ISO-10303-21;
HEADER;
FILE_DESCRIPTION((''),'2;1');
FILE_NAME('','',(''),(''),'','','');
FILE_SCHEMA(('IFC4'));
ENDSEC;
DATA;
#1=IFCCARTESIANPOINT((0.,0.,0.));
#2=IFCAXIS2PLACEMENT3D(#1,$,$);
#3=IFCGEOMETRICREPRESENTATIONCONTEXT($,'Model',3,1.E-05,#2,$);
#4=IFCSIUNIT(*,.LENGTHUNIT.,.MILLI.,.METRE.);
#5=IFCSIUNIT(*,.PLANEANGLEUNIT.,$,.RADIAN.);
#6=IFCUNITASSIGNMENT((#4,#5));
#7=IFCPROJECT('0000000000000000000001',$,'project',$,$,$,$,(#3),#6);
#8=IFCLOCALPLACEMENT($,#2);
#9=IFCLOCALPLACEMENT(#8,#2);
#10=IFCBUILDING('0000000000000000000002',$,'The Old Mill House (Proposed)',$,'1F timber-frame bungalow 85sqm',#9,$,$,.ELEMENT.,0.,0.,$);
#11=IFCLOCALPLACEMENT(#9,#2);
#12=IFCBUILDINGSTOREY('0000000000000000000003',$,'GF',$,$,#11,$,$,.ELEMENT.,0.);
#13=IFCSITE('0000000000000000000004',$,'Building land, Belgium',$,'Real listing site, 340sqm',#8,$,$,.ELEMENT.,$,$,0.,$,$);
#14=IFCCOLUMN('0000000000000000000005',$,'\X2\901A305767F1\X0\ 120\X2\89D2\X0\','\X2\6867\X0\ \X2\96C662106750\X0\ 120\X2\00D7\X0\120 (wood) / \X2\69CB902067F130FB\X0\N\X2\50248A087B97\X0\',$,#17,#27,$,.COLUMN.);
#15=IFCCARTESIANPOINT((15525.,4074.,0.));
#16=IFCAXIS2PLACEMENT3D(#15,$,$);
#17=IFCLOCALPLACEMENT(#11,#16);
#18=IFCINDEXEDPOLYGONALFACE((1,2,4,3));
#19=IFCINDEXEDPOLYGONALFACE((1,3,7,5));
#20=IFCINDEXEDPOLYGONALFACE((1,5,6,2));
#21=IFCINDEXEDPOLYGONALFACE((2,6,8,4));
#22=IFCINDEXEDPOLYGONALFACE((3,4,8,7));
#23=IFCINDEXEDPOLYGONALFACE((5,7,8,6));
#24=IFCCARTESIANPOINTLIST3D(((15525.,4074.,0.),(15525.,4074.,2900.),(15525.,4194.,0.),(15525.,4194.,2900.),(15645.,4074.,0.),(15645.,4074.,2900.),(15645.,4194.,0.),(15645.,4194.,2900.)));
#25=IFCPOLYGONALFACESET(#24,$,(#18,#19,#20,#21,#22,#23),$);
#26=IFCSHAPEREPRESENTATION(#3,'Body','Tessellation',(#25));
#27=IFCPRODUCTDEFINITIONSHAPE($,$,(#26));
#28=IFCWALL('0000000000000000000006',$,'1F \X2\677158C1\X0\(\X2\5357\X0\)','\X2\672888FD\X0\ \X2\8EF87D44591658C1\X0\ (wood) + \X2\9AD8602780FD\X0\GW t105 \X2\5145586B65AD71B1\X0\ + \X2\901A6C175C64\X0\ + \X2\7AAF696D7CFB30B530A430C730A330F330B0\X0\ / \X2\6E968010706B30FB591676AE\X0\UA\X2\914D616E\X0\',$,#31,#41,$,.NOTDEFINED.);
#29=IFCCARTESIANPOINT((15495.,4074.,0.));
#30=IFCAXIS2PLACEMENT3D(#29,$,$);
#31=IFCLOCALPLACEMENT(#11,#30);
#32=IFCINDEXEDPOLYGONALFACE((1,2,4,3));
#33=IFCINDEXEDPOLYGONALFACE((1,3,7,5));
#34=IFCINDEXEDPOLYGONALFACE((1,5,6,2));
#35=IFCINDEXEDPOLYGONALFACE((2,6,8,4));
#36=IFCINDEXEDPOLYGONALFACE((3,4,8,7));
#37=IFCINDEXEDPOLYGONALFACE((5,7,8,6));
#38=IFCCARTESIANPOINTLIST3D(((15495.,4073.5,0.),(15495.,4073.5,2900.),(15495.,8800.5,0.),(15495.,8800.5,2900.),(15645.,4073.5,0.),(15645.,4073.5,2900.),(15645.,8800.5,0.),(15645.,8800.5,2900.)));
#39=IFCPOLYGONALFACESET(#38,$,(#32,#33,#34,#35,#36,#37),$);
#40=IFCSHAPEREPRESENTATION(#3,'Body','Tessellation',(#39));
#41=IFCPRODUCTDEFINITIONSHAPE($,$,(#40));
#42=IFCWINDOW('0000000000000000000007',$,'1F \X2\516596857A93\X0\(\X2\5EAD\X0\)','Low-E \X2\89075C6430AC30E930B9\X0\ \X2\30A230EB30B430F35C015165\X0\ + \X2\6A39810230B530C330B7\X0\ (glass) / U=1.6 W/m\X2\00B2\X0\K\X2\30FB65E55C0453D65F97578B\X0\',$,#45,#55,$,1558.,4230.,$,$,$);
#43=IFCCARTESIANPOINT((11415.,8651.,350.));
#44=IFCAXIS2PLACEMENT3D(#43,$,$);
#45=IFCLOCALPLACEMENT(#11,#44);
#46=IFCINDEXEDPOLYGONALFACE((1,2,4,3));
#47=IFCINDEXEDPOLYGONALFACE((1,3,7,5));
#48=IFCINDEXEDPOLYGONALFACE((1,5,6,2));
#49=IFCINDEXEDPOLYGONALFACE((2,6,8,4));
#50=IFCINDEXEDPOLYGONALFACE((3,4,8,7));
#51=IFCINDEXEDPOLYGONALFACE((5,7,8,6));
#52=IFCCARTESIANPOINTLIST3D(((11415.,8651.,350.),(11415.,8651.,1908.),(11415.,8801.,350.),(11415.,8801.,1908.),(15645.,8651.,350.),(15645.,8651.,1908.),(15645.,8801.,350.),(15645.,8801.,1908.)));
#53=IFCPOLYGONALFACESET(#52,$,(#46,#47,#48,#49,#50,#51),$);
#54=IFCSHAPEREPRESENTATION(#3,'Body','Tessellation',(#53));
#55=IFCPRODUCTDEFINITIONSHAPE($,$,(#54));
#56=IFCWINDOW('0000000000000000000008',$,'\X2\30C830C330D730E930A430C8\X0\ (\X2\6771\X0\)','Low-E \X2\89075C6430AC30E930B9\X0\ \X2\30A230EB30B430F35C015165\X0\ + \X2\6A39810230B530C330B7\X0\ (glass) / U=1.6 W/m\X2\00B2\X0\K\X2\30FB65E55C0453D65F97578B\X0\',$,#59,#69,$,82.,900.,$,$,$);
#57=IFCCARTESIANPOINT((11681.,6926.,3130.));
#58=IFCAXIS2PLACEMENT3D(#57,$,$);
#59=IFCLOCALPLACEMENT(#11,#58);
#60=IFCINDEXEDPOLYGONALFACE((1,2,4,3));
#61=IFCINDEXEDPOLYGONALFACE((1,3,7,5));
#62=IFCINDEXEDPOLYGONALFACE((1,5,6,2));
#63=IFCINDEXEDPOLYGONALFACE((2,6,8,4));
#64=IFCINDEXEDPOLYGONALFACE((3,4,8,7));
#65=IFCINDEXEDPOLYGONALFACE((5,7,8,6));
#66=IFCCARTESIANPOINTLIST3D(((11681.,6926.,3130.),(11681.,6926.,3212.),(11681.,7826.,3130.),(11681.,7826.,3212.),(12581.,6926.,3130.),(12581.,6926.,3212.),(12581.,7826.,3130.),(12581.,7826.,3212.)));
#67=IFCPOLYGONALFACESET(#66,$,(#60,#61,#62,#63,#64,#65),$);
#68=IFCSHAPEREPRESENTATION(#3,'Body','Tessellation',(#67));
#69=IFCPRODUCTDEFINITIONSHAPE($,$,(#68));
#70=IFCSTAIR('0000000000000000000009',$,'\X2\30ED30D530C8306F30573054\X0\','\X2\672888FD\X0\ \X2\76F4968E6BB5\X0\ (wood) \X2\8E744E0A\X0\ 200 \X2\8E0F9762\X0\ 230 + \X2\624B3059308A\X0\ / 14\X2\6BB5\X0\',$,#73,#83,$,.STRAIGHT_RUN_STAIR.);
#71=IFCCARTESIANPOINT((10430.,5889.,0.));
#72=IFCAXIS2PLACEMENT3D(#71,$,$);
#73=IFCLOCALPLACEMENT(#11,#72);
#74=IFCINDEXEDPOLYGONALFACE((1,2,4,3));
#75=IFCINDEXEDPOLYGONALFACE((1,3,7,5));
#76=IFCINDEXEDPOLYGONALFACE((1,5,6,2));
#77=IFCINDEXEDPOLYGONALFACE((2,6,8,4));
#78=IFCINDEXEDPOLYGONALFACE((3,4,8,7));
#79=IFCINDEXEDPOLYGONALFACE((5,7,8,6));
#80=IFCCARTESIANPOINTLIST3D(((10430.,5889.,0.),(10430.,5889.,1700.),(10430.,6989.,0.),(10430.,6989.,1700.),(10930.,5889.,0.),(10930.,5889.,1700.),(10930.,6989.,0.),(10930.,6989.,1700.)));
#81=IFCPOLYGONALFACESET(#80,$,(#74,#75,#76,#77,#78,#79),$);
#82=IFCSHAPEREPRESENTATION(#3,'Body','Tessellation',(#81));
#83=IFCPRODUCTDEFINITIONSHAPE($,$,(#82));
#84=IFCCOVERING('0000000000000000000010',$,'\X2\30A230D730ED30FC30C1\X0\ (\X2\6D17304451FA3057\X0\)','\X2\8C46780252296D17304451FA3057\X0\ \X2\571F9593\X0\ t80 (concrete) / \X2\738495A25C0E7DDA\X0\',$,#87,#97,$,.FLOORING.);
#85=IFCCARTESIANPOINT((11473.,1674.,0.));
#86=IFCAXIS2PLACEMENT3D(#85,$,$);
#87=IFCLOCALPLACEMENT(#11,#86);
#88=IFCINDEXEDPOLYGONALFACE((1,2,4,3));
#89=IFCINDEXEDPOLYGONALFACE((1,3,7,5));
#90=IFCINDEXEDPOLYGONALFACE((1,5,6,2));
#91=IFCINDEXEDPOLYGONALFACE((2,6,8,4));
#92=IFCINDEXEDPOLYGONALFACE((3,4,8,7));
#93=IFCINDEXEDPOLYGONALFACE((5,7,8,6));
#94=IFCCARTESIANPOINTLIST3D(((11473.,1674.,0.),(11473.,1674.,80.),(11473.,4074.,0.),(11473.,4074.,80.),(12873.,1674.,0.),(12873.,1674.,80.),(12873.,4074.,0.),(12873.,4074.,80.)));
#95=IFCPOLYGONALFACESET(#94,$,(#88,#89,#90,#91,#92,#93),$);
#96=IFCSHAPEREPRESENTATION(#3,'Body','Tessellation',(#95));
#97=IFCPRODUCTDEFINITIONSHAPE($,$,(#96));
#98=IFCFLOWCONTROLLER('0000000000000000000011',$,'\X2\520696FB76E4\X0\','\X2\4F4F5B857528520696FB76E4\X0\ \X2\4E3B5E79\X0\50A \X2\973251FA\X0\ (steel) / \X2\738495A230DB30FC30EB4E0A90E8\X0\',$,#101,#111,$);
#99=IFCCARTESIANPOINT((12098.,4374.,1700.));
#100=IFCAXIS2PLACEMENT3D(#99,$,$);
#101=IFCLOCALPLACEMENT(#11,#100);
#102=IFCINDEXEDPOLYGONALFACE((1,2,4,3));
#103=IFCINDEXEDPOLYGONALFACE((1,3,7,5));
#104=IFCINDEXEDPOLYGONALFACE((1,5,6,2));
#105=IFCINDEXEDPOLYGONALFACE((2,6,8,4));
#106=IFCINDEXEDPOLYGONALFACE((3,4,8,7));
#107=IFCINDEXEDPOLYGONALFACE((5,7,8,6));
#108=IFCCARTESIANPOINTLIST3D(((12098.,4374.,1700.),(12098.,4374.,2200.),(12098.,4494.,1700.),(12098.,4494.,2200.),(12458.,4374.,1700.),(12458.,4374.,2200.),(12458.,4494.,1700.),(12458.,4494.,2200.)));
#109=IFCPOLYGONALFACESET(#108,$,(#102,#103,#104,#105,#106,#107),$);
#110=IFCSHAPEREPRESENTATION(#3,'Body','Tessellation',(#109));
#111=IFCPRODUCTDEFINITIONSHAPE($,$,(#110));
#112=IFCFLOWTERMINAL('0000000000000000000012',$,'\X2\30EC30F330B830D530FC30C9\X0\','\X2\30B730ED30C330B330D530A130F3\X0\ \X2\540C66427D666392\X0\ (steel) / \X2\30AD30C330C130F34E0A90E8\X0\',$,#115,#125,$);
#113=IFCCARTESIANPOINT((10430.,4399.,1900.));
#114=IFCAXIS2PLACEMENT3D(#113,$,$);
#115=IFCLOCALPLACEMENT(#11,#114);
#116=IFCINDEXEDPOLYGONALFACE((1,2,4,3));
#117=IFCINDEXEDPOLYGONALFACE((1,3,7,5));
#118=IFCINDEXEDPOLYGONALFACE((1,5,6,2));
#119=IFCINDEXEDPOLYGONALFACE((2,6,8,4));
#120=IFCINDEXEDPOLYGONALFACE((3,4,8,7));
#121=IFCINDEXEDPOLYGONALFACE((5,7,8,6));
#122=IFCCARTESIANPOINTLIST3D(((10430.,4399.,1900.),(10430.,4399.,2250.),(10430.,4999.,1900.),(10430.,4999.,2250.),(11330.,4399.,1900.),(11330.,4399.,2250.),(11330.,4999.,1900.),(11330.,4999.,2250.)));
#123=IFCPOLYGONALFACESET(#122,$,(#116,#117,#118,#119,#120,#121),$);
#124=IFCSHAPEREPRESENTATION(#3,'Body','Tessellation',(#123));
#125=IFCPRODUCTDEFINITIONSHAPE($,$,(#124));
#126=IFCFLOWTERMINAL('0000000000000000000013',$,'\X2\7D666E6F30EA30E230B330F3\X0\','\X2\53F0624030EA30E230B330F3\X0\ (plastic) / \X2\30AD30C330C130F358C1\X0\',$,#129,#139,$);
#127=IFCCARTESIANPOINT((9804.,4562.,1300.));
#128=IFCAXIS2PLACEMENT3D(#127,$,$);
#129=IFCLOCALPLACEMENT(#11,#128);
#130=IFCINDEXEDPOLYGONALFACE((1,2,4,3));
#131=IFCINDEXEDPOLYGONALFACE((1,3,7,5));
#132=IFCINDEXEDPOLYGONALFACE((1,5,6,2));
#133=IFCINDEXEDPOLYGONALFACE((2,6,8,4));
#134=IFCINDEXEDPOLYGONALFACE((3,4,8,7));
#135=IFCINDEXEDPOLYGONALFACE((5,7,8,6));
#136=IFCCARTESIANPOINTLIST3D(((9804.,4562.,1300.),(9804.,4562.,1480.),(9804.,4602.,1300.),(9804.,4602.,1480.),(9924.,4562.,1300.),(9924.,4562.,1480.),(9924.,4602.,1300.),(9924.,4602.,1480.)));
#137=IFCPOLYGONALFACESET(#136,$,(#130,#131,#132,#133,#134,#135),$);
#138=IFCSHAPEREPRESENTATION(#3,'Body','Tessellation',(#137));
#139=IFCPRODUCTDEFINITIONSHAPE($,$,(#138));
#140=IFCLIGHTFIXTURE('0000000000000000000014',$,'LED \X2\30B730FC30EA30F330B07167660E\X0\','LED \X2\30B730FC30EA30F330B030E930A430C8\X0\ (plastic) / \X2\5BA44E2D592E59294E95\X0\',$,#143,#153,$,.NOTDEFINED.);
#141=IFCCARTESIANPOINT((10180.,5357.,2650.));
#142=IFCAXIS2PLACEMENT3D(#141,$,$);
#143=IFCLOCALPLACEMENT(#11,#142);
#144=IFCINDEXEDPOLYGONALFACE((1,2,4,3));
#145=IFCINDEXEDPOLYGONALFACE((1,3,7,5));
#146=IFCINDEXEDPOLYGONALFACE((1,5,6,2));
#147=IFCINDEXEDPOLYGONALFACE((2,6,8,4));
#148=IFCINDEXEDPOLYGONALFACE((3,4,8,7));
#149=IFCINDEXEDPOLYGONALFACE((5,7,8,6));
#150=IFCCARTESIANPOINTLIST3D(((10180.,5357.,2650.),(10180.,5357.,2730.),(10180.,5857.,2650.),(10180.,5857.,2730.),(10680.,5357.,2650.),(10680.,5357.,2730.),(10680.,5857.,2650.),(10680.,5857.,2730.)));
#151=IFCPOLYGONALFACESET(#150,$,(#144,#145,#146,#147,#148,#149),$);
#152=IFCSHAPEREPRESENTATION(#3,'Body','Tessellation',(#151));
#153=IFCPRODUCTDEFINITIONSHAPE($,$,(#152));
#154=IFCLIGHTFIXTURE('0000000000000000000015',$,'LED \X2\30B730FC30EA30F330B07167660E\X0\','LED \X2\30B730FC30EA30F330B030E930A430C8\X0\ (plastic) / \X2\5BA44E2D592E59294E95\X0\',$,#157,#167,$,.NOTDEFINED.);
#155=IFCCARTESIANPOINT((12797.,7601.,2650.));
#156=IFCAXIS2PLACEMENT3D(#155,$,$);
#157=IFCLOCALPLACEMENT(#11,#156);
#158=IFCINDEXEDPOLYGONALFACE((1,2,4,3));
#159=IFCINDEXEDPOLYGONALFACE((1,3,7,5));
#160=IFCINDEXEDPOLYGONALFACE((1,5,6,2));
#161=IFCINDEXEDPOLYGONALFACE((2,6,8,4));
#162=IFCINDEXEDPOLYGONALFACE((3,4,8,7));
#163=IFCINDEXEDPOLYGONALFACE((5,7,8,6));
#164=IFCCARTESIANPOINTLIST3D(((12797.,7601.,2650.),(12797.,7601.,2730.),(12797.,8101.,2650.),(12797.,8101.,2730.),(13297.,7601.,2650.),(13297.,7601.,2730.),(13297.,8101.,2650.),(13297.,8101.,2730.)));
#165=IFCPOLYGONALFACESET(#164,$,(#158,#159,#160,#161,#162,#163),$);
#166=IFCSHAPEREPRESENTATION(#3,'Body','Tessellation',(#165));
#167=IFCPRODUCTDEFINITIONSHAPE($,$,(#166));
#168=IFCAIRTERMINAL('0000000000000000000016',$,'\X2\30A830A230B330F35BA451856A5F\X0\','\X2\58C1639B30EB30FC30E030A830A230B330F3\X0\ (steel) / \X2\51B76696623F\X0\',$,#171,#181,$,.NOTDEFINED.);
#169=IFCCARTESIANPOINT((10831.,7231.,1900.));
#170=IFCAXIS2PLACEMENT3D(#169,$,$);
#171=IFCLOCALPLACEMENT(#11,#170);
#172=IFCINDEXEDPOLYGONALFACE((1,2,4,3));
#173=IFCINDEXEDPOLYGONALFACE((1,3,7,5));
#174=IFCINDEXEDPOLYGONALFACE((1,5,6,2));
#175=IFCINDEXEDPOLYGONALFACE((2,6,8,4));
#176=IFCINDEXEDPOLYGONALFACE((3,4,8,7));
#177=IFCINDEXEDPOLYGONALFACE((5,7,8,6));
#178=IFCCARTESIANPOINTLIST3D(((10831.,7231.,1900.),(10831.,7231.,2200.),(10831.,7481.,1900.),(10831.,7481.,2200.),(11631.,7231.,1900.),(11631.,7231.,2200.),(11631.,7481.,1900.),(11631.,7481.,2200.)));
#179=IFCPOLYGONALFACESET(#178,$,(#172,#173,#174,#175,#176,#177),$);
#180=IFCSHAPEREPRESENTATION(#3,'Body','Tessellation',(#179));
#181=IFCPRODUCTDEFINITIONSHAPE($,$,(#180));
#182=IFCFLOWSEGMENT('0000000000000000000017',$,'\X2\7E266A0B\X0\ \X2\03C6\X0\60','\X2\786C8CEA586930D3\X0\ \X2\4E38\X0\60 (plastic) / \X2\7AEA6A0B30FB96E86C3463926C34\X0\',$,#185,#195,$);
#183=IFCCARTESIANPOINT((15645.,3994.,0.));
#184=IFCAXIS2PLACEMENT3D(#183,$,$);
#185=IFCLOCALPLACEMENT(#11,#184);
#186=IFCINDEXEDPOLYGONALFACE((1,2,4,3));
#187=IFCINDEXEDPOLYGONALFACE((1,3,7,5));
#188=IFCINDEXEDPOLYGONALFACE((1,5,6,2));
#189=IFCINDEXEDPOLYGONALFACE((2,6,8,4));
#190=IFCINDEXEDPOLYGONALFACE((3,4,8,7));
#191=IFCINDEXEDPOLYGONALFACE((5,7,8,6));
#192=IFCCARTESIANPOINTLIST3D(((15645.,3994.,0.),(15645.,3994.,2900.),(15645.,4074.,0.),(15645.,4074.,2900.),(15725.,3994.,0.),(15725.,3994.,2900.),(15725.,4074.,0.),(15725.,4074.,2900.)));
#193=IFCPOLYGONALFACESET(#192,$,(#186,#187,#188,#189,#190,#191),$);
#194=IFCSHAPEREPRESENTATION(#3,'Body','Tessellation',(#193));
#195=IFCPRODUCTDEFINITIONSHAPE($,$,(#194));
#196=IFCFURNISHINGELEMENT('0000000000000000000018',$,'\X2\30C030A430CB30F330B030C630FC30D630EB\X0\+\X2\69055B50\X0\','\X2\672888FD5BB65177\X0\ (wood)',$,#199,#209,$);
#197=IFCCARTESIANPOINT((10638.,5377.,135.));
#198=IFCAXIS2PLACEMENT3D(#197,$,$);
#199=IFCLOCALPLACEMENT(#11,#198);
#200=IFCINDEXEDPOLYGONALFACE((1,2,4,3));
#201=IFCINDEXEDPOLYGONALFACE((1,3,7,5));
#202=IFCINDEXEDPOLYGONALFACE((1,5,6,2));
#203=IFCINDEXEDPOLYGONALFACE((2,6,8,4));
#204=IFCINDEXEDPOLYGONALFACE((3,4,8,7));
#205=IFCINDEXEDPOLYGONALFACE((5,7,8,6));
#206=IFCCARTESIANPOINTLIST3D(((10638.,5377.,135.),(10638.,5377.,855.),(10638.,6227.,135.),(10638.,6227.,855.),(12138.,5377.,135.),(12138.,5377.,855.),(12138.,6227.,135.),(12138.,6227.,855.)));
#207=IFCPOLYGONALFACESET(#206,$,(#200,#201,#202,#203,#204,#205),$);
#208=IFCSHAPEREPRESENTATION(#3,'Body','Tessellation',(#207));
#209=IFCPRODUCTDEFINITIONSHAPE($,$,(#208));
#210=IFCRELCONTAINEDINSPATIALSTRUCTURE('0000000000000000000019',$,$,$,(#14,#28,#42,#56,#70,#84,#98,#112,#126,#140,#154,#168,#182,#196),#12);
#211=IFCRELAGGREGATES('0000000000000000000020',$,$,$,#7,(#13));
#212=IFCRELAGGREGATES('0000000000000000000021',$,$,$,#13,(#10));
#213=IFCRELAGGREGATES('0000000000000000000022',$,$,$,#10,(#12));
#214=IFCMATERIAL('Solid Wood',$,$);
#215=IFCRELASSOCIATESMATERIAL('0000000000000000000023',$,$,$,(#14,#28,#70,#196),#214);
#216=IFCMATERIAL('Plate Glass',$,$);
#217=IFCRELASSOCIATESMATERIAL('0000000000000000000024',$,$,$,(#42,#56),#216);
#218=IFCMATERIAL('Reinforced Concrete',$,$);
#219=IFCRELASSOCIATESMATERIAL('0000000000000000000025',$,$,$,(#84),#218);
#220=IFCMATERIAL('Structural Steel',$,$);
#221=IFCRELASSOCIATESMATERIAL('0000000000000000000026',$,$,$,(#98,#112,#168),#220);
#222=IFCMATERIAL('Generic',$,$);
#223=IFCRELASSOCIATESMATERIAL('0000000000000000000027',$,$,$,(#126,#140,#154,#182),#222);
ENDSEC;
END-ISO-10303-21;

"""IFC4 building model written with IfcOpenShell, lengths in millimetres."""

from ifc_helpers import new_model, si_unit, frame, frame_2d, origin, place, context, project, spatial, rectangle, extrude, material, element, fill, save


model = new_model("IFC4")

# Units and contexts
model_context = context("Model", 3, precision=1e-05, world=origin())
ifc_project = project(units=[si_unit("LENGTHUNIT", "METRE", prefix="MILLI"), si_unit("PLANEANGLEUNIT", "RADIAN")], contexts=[model_context])

# Site, building, storey
site_placement = place(None, origin())
site = spatial("IfcSite", under=ifc_project, at=site_placement, Name="Building land, Belgium", ObjectType="Real listing site, 340sqm", CompositionType="ELEMENT", RefElevation=0.0)
building_placement = place(site_placement, origin())
building = spatial("IfcBuilding", under=site, at=building_placement, Name="The Old Mill House (Proposed)", ObjectType="1F timber-frame bungalow 85sqm", CompositionType="ELEMENT", ElevationOfRefHeight=0.0, ElevationOfTerrain=0.0)
storey_placement = place(building_placement, origin())
storey = spatial("IfcBuildingStorey", under=building, at=storey_placement, Name="GF", CompositionType="ELEMENT", Elevation=0.0)

# Column
ifc_material_1 = material(Name="Solid Wood")
column_1_placement = place(storey_placement, frame((15525.0, 4074.0, 0.0)))
element("IfcColumn", 1, at=column_1_placement, inside=storey, material=ifc_material_1, Name="通し柱 120角", Description="桧 集成材 120×120 (wood) / 構造柱・N値計算", PredefinedType="COLUMN", context=model_context, shape_type="SweptSolid", body=[
    extrude(rectangle(XDim=120.0, YDim=120.0, at=frame_2d((60.0, 60.0))), frame((15525.0, 4074.0, 0.0)), (0.0, 0.0, 1.0), 2900.0),
])

# Wall, opening, window
wall_1_placement = place(storey_placement, frame((15495.0, 4074.0, 0.0)))
wall_1 = element("IfcWall", 2, at=wall_1_placement, inside=storey, material=ifc_material_1, Name="1F 東壁(南)", Description="木製 軸組外壁 (wood) + 高性能GW t105 充填断熱 + 通気層 + 窯業系サイディング / 準耐火・外皮UA配慮", PredefinedType="NOTDEFINED", context=model_context, shape_type="SweptSolid", body=[
    extrude(rectangle(XDim=150.0, YDim=4727.0, at=frame_2d((75.0, 2363.0))), frame((15495.0, 4074.0, 0.0)), (0.0, 0.0, 1.0), 2900.0),
])
opening_1_placement = place(storey_placement, frame((11415.0, 8651.0, 350.0)))
opening_1 = element("IfcOpeningElement", 3, at=opening_1_placement, cuts=wall_1, PredefinedType="NOTDEFINED", context=model_context, shape_type="SweptSolid", body=[
    extrude(rectangle(XDim=4230.0, YDim=150.0, at=frame_2d((2115.0, 75.0))), frame((11415.0, 8651.0, 350.0)), (0.0, 0.0, 1.0), 1558.0),
])
ifc_material_2 = material(Name="Plate Glass")
window_1_placement = place(storey_placement, frame((11415.0, 8651.0, 350.0)))
window_1 = element("IfcWindow", 4, at=window_1_placement, inside=storey, material=ifc_material_2, Name="1F 入隅窓(庭)", Description="Low-E 複層ガラス アルゴン封入 + 樹脂サッシ (glass) / U=1.6 W/m²K・日射取得型", OverallHeight=1558.0, OverallWidth=4230.0, context=model_context, shape_type="SweptSolid", body=[
    extrude(rectangle(XDim=4230.0, YDim=150.0, at=frame_2d((2115.0, 75.0))), frame((11415.0, 8651.0, 350.0)), (0.0, 0.0, 1.0), 1558.0),
])
fill(opening_1, window_1)

# Window
window_2_placement = place(storey_placement, frame((11681.0, 6926.0, 3130.0)))
element("IfcWindow", 5, at=window_2_placement, inside=storey, material=ifc_material_2, Name="トップライト (東)", Description="Low-E 複層ガラス アルゴン封入 + 樹脂サッシ (glass) / U=1.6 W/m²K・日射取得型", OverallHeight=82.0, OverallWidth=900.0, context=model_context, shape_type="SweptSolid", body=[
    extrude(rectangle(XDim=900.0, YDim=900.0, at=frame_2d((450.0, 450.0))), frame((11681.0, 6926.0, 3130.0)), (0.0, 0.0, 1.0), 82.0),
])

# Stair
stair_placement = place(storey_placement, frame((10430.0, 5889.0, 0.0)))
element("IfcStair", 6, at=stair_placement, inside=storey, material=ifc_material_1, Name="ロフトはしご", Description="木製 直階段 (wood) 蹴上 200 踏面 230 + 手すり / 14段", PredefinedType="STRAIGHT_RUN_STAIR", context=model_context, shape_type="SweptSolid", body=[
    extrude(rectangle(XDim=500.0, YDim=1100.0, at=frame_2d((250.0, 550.0))), frame((10430.0, 5889.0, 0.0)), (0.0, 0.0, 1.0), 1700.0),
])

# Covering
ifc_material_3 = material(Name="Reinforced Concrete")
covering_placement = place(storey_placement, frame((11473.0, 1674.0, 0.0)))
element("IfcCovering", 7, at=covering_placement, inside=storey, material=ifc_material_3, Name="アプローチ (洗い出し)", Description="豆砂利洗い出し 土間 t80 (concrete) / 玄関導線", PredefinedType="FLOORING", context=model_context, shape_type="SweptSolid", body=[
    extrude(rectangle(XDim=1400.0, YDim=2400.0, at=frame_2d((700.0, 1200.0))), frame((11473.0, 1674.0, 0.0)), (0.0, 0.0, 1.0), 80.0),
])

# Flow controller
ifc_material_4 = material(Name="Structural Steel")
flow_controller_placement = place(storey_placement, frame((12098.0, 4374.0, 1700.0)))
element("IfcFlowController", 8, at=flow_controller_placement, inside=storey, material=ifc_material_4, Name="分電盤", Description="住宅用分電盤 主幹50A 露出 (steel) / 玄関ホール上部", context=model_context, shape_type="SweptSolid", body=[
    extrude(rectangle(XDim=360.0, YDim=120.0, at=frame_2d((180.0, 60.0))), frame((12098.0, 4374.0, 1700.0)), (0.0, 0.0, 1.0), 500.0),
])

# Flow terminals
flow_terminal_1_placement = place(storey_placement, frame((10430.0, 4399.0, 1900.0)))
element("IfcFlowTerminal", 9, at=flow_terminal_1_placement, inside=storey, material=ifc_material_4, Name="レンジフード", Description="シロッコファン 同時給排 (steel) / キッチン上部", context=model_context, shape_type="SweptSolid", body=[
    extrude(rectangle(XDim=900.0, YDim=600.0, at=frame_2d((450.0, 300.0))), frame((10430.0, 4399.0, 1900.0)), (0.0, 0.0, 1.0), 350.0),
])
ifc_material_5 = material(Name="Generic")
flow_terminal_2_placement = place(storey_placement, frame((9804.0, 4562.0, 1300.0)))
element("IfcFlowTerminal", 10, at=flow_terminal_2_placement, inside=storey, material=ifc_material_5, Name="給湯リモコン", Description="台所リモコン (plastic) / キッチン壁", context=model_context, shape_type="SweptSolid", body=[
    extrude(rectangle(XDim=120.0, YDim=40.0, at=frame_2d((60.0, 20.0))), frame((9804.0, 4562.0, 1300.0)), (0.0, 0.0, 1.0), 180.0),
])

# Light fixtures
light_fixture_1_placement = place(storey_placement, frame((10180.0, 5357.0, 2650.0)))
element("IfcLightFixture", 11, at=light_fixture_1_placement, inside=storey, material=ifc_material_5, Name="LED シーリング照明", Description="LED シーリングライト (plastic) / 室中央天井", PredefinedType="NOTDEFINED", context=model_context, shape_type="SweptSolid", body=[
    extrude(rectangle(XDim=500.0, YDim=500.0, at=frame_2d((250.0, 250.0))), frame((10180.0, 5357.0, 2650.0)), (0.0, 0.0, 1.0), 80.0),
])
light_fixture_2_placement = place(storey_placement, frame((12797.0, 7601.0, 2650.0)))
element("IfcLightFixture", 12, at=light_fixture_2_placement, inside=storey, material=ifc_material_5, Name="LED シーリング照明", Description="LED シーリングライト (plastic) / 室中央天井", PredefinedType="NOTDEFINED", context=model_context, shape_type="SweptSolid", body=[
    extrude(rectangle(XDim=500.0, YDim=500.0, at=frame_2d((250.0, 250.0))), frame((12797.0, 7601.0, 2650.0)), (0.0, 0.0, 1.0), 80.0),
])

# Air terminal
air_terminal_placement = place(storey_placement, frame((10831.0, 7231.0, 1900.0)))
element("IfcAirTerminal", 13, at=air_terminal_placement, inside=storey, material=ifc_material_4, Name="エアコン室内機", Description="壁掛ルームエアコン (steel) / 冷暖房", PredefinedType="NOTDEFINED", context=model_context, shape_type="SweptSolid", body=[
    extrude(rectangle(XDim=800.0, YDim=250.0, at=frame_2d((400.0, 125.0))), frame((10831.0, 7231.0, 1900.0)), (0.0, 0.0, 1.0), 300.0),
])

# Flow segment
flow_segment_placement = place(storey_placement, frame((15645.0, 3994.0, 0.0)))
element("IfcFlowSegment", 14, at=flow_segment_placement, inside=storey, material=ifc_material_5, Name="縦樋 φ60", Description="硬質塩ビ 丸60 (plastic) / 竪樋・雨水排水", context=model_context, shape_type="SweptSolid", body=[
    extrude(rectangle(XDim=80.0, YDim=80.0, at=frame_2d((40.0, 40.0))), frame((15645.0, 3994.0, 0.0)), (0.0, 0.0, 1.0), 2900.0),
])

# Furnishing element
furnishing_1_placement = place(storey_placement, frame((10638.0, 5377.0, 135.0)))
element("IfcFurnishingElement", 15, at=furnishing_1_placement, inside=storey, material=ifc_material_1, Name="ダイニングテーブル+椅子", Description="木製家具 (wood)", context=model_context, shape_type="SweptSolid", body=[
    extrude(rectangle(XDim=1500.0, YDim=850.0, at=frame_2d((750.0, 425.0))), frame((10638.0, 5377.0, 135.0)), (0.0, 0.0, 1.0), 720.0),
])

save(model, "model.ifc")
